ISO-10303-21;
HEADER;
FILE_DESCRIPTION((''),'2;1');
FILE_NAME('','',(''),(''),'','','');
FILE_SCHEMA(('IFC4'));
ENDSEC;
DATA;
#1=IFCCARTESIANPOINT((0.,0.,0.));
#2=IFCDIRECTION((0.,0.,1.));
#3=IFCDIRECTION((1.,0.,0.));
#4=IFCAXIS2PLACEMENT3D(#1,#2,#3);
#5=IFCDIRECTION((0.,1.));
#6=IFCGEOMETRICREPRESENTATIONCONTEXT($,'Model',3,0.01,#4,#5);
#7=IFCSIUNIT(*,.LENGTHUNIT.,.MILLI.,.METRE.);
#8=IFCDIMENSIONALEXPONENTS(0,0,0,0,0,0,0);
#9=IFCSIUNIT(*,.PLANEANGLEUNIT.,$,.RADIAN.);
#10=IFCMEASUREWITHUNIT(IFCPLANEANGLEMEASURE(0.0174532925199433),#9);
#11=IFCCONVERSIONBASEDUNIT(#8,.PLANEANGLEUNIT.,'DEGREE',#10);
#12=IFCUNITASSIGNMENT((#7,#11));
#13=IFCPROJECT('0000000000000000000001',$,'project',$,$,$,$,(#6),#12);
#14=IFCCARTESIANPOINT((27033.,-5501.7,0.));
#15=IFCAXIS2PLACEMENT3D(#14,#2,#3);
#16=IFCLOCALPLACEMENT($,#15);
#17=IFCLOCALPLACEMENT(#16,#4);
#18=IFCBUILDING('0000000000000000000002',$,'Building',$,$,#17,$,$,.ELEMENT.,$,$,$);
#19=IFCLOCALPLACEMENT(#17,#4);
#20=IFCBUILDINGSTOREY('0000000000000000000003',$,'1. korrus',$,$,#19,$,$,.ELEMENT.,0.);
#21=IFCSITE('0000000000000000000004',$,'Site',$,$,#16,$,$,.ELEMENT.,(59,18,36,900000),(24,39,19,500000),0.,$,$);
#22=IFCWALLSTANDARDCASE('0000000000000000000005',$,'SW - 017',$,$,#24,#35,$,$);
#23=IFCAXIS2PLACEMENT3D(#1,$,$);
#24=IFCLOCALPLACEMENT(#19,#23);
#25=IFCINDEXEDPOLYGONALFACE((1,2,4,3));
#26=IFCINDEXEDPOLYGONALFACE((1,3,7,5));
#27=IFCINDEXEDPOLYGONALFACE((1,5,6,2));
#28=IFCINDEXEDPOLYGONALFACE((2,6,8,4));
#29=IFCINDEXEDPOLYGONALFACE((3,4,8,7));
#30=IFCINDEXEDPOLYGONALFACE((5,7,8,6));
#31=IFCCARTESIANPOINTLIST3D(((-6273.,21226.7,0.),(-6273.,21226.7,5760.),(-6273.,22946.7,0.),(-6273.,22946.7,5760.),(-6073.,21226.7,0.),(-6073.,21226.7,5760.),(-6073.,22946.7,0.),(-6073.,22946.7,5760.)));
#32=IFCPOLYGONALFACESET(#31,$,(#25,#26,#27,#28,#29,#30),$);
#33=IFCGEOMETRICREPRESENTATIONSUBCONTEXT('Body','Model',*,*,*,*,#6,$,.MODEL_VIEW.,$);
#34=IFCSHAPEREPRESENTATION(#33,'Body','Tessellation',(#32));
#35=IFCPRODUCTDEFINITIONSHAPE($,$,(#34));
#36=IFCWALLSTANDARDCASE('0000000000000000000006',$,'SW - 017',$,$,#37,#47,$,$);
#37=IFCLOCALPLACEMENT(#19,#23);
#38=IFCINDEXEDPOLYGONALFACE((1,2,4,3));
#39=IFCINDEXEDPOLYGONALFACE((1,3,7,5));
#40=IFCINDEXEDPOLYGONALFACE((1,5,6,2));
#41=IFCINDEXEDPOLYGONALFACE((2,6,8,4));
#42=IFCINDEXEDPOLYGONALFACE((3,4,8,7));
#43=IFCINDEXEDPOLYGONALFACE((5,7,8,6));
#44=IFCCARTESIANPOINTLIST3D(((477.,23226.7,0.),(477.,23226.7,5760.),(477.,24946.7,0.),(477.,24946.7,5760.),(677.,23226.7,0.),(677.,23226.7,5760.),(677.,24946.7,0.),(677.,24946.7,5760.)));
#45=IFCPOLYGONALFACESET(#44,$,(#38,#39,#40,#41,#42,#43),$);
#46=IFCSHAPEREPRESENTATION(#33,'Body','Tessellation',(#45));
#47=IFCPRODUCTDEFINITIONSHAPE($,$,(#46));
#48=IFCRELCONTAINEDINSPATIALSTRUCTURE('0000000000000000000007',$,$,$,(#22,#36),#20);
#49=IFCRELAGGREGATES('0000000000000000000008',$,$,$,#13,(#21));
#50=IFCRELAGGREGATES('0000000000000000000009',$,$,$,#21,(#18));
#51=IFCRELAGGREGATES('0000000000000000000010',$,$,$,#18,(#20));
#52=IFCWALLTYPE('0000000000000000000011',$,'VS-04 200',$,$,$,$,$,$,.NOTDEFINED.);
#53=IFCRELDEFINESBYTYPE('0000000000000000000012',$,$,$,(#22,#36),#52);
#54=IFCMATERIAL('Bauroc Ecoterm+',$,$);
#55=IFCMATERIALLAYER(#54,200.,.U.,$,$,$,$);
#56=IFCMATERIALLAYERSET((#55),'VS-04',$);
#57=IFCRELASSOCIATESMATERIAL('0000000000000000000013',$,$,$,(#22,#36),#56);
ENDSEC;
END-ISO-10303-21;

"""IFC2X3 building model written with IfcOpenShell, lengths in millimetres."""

from ifc_helpers import new_model, entity, si_unit, converted_unit, direction, frame, origin_with_axes, place, context, subcontext, project, spatial, polyline, outline, extrude, material, layer, layer_set, layer_usage, type_object, element, save


model = new_model("IFC2X3")

# Units and contexts
model_context = context("Model", 3, precision=0.01, world=origin_with_axes(), true_north=direction((0.0, 1.0)))
body_context = subcontext(model_context, "Body", "Model", "MODEL_VIEW")
ifc_project = project(units=[si_unit("LENGTHUNIT", "METRE", prefix="MILLI"), converted_unit("PLANEANGLEUNIT", "DEGREE", entity("IfcPlaneAngleMeasure", 0.0174532925199433), si_unit("PLANEANGLEUNIT", "RADIAN"), dimensions=[0, 0, 0, 0, 0, 0, 0])], contexts=[model_context])

# Site, building, storey
site_placement = place(None, frame((27033.0, -5501.7, 0.0), z_axis=(0.0, 0.0, 1.0), x_axis=(1.0, 0.0, 0.0)))
site = spatial("IfcSite", under=ifc_project, at=site_placement, Name="Site", CompositionType="ELEMENT", RefLatitude=(59, 18, 36, 900000), RefLongitude=(24, 39, 19, 500000), RefElevation=0.0)
building_placement = place(site_placement, origin_with_axes())
building = spatial("IfcBuilding", under=site, at=building_placement, Name="Building", CompositionType="ELEMENT")
storey_placement = place(building_placement, origin_with_axes())
storey = spatial("IfcBuildingStorey", under=building, at=storey_placement, Name="1. korrus", CompositionType="ELEMENT", Elevation=0.0)

# Shared definitions
ifc_material_1 = material(Name="Bauroc Ecoterm+")

# Walls
ifc_layer_1 = layer(ifc_material_1, 200.0, ventilated="UNKNOWN")
ifc_layer_set_1 = layer_set([ifc_layer_1], Name="VS-04")
ifc_layer_usage_1 = layer_usage(ifc_layer_set_1, "AXIS2", "NEGATIVE", 0.0)
wall_type_1 = type_object("IfcWallType", Name="VS-04 200", PredefinedType="NOTDEFINED")
wall_1_placement = place(storey_placement, frame((-6273.0, 21226.7, 0.0), z_axis=(0.0, 0.0, 1.0), x_axis=(0.0, 1.0, 0.0)))
element("IfcWallStandardCase", 1, at=wall_1_placement, inside=storey, type_object=wall_type_1, material=ifc_layer_usage_1, Name="SW - 017", context=body_context, shape_type="SweptSolid", body=[
    extrude(outline(polyline([(0.0, -200.0), (1720.0, -200.0), (1720.0, 0.0), (0.0, 0.0), (0.0, -200.0)])), origin_with_axes(), (0.0, 0.0, 1.0), 5760.0),
])
ifc_layer_usage_2 = layer_usage(ifc_layer_set_1, "AXIS2", "NEGATIVE", 0.0)
wall_2_placement = place(storey_placement, frame((477.0, 23226.7, 0.0), z_axis=(0.0, 0.0, 1.0), x_axis=(0.0, 1.0, 0.0)))
element("IfcWallStandardCase", 2, at=wall_2_placement, inside=storey, type_object=wall_type_1, material=ifc_layer_usage_2, Name="SW - 017", context=body_context, shape_type="SweptSolid", body=[
    extrude(outline(polyline([(0.0, -200.0), (1720.0, -200.0), (1720.0, 0.0), (0.0, 0.0), (0.0, -200.0)])), origin_with_axes(), (0.0, 0.0, 1.0), 5760.0),
])

save(model, "model.ifc")
